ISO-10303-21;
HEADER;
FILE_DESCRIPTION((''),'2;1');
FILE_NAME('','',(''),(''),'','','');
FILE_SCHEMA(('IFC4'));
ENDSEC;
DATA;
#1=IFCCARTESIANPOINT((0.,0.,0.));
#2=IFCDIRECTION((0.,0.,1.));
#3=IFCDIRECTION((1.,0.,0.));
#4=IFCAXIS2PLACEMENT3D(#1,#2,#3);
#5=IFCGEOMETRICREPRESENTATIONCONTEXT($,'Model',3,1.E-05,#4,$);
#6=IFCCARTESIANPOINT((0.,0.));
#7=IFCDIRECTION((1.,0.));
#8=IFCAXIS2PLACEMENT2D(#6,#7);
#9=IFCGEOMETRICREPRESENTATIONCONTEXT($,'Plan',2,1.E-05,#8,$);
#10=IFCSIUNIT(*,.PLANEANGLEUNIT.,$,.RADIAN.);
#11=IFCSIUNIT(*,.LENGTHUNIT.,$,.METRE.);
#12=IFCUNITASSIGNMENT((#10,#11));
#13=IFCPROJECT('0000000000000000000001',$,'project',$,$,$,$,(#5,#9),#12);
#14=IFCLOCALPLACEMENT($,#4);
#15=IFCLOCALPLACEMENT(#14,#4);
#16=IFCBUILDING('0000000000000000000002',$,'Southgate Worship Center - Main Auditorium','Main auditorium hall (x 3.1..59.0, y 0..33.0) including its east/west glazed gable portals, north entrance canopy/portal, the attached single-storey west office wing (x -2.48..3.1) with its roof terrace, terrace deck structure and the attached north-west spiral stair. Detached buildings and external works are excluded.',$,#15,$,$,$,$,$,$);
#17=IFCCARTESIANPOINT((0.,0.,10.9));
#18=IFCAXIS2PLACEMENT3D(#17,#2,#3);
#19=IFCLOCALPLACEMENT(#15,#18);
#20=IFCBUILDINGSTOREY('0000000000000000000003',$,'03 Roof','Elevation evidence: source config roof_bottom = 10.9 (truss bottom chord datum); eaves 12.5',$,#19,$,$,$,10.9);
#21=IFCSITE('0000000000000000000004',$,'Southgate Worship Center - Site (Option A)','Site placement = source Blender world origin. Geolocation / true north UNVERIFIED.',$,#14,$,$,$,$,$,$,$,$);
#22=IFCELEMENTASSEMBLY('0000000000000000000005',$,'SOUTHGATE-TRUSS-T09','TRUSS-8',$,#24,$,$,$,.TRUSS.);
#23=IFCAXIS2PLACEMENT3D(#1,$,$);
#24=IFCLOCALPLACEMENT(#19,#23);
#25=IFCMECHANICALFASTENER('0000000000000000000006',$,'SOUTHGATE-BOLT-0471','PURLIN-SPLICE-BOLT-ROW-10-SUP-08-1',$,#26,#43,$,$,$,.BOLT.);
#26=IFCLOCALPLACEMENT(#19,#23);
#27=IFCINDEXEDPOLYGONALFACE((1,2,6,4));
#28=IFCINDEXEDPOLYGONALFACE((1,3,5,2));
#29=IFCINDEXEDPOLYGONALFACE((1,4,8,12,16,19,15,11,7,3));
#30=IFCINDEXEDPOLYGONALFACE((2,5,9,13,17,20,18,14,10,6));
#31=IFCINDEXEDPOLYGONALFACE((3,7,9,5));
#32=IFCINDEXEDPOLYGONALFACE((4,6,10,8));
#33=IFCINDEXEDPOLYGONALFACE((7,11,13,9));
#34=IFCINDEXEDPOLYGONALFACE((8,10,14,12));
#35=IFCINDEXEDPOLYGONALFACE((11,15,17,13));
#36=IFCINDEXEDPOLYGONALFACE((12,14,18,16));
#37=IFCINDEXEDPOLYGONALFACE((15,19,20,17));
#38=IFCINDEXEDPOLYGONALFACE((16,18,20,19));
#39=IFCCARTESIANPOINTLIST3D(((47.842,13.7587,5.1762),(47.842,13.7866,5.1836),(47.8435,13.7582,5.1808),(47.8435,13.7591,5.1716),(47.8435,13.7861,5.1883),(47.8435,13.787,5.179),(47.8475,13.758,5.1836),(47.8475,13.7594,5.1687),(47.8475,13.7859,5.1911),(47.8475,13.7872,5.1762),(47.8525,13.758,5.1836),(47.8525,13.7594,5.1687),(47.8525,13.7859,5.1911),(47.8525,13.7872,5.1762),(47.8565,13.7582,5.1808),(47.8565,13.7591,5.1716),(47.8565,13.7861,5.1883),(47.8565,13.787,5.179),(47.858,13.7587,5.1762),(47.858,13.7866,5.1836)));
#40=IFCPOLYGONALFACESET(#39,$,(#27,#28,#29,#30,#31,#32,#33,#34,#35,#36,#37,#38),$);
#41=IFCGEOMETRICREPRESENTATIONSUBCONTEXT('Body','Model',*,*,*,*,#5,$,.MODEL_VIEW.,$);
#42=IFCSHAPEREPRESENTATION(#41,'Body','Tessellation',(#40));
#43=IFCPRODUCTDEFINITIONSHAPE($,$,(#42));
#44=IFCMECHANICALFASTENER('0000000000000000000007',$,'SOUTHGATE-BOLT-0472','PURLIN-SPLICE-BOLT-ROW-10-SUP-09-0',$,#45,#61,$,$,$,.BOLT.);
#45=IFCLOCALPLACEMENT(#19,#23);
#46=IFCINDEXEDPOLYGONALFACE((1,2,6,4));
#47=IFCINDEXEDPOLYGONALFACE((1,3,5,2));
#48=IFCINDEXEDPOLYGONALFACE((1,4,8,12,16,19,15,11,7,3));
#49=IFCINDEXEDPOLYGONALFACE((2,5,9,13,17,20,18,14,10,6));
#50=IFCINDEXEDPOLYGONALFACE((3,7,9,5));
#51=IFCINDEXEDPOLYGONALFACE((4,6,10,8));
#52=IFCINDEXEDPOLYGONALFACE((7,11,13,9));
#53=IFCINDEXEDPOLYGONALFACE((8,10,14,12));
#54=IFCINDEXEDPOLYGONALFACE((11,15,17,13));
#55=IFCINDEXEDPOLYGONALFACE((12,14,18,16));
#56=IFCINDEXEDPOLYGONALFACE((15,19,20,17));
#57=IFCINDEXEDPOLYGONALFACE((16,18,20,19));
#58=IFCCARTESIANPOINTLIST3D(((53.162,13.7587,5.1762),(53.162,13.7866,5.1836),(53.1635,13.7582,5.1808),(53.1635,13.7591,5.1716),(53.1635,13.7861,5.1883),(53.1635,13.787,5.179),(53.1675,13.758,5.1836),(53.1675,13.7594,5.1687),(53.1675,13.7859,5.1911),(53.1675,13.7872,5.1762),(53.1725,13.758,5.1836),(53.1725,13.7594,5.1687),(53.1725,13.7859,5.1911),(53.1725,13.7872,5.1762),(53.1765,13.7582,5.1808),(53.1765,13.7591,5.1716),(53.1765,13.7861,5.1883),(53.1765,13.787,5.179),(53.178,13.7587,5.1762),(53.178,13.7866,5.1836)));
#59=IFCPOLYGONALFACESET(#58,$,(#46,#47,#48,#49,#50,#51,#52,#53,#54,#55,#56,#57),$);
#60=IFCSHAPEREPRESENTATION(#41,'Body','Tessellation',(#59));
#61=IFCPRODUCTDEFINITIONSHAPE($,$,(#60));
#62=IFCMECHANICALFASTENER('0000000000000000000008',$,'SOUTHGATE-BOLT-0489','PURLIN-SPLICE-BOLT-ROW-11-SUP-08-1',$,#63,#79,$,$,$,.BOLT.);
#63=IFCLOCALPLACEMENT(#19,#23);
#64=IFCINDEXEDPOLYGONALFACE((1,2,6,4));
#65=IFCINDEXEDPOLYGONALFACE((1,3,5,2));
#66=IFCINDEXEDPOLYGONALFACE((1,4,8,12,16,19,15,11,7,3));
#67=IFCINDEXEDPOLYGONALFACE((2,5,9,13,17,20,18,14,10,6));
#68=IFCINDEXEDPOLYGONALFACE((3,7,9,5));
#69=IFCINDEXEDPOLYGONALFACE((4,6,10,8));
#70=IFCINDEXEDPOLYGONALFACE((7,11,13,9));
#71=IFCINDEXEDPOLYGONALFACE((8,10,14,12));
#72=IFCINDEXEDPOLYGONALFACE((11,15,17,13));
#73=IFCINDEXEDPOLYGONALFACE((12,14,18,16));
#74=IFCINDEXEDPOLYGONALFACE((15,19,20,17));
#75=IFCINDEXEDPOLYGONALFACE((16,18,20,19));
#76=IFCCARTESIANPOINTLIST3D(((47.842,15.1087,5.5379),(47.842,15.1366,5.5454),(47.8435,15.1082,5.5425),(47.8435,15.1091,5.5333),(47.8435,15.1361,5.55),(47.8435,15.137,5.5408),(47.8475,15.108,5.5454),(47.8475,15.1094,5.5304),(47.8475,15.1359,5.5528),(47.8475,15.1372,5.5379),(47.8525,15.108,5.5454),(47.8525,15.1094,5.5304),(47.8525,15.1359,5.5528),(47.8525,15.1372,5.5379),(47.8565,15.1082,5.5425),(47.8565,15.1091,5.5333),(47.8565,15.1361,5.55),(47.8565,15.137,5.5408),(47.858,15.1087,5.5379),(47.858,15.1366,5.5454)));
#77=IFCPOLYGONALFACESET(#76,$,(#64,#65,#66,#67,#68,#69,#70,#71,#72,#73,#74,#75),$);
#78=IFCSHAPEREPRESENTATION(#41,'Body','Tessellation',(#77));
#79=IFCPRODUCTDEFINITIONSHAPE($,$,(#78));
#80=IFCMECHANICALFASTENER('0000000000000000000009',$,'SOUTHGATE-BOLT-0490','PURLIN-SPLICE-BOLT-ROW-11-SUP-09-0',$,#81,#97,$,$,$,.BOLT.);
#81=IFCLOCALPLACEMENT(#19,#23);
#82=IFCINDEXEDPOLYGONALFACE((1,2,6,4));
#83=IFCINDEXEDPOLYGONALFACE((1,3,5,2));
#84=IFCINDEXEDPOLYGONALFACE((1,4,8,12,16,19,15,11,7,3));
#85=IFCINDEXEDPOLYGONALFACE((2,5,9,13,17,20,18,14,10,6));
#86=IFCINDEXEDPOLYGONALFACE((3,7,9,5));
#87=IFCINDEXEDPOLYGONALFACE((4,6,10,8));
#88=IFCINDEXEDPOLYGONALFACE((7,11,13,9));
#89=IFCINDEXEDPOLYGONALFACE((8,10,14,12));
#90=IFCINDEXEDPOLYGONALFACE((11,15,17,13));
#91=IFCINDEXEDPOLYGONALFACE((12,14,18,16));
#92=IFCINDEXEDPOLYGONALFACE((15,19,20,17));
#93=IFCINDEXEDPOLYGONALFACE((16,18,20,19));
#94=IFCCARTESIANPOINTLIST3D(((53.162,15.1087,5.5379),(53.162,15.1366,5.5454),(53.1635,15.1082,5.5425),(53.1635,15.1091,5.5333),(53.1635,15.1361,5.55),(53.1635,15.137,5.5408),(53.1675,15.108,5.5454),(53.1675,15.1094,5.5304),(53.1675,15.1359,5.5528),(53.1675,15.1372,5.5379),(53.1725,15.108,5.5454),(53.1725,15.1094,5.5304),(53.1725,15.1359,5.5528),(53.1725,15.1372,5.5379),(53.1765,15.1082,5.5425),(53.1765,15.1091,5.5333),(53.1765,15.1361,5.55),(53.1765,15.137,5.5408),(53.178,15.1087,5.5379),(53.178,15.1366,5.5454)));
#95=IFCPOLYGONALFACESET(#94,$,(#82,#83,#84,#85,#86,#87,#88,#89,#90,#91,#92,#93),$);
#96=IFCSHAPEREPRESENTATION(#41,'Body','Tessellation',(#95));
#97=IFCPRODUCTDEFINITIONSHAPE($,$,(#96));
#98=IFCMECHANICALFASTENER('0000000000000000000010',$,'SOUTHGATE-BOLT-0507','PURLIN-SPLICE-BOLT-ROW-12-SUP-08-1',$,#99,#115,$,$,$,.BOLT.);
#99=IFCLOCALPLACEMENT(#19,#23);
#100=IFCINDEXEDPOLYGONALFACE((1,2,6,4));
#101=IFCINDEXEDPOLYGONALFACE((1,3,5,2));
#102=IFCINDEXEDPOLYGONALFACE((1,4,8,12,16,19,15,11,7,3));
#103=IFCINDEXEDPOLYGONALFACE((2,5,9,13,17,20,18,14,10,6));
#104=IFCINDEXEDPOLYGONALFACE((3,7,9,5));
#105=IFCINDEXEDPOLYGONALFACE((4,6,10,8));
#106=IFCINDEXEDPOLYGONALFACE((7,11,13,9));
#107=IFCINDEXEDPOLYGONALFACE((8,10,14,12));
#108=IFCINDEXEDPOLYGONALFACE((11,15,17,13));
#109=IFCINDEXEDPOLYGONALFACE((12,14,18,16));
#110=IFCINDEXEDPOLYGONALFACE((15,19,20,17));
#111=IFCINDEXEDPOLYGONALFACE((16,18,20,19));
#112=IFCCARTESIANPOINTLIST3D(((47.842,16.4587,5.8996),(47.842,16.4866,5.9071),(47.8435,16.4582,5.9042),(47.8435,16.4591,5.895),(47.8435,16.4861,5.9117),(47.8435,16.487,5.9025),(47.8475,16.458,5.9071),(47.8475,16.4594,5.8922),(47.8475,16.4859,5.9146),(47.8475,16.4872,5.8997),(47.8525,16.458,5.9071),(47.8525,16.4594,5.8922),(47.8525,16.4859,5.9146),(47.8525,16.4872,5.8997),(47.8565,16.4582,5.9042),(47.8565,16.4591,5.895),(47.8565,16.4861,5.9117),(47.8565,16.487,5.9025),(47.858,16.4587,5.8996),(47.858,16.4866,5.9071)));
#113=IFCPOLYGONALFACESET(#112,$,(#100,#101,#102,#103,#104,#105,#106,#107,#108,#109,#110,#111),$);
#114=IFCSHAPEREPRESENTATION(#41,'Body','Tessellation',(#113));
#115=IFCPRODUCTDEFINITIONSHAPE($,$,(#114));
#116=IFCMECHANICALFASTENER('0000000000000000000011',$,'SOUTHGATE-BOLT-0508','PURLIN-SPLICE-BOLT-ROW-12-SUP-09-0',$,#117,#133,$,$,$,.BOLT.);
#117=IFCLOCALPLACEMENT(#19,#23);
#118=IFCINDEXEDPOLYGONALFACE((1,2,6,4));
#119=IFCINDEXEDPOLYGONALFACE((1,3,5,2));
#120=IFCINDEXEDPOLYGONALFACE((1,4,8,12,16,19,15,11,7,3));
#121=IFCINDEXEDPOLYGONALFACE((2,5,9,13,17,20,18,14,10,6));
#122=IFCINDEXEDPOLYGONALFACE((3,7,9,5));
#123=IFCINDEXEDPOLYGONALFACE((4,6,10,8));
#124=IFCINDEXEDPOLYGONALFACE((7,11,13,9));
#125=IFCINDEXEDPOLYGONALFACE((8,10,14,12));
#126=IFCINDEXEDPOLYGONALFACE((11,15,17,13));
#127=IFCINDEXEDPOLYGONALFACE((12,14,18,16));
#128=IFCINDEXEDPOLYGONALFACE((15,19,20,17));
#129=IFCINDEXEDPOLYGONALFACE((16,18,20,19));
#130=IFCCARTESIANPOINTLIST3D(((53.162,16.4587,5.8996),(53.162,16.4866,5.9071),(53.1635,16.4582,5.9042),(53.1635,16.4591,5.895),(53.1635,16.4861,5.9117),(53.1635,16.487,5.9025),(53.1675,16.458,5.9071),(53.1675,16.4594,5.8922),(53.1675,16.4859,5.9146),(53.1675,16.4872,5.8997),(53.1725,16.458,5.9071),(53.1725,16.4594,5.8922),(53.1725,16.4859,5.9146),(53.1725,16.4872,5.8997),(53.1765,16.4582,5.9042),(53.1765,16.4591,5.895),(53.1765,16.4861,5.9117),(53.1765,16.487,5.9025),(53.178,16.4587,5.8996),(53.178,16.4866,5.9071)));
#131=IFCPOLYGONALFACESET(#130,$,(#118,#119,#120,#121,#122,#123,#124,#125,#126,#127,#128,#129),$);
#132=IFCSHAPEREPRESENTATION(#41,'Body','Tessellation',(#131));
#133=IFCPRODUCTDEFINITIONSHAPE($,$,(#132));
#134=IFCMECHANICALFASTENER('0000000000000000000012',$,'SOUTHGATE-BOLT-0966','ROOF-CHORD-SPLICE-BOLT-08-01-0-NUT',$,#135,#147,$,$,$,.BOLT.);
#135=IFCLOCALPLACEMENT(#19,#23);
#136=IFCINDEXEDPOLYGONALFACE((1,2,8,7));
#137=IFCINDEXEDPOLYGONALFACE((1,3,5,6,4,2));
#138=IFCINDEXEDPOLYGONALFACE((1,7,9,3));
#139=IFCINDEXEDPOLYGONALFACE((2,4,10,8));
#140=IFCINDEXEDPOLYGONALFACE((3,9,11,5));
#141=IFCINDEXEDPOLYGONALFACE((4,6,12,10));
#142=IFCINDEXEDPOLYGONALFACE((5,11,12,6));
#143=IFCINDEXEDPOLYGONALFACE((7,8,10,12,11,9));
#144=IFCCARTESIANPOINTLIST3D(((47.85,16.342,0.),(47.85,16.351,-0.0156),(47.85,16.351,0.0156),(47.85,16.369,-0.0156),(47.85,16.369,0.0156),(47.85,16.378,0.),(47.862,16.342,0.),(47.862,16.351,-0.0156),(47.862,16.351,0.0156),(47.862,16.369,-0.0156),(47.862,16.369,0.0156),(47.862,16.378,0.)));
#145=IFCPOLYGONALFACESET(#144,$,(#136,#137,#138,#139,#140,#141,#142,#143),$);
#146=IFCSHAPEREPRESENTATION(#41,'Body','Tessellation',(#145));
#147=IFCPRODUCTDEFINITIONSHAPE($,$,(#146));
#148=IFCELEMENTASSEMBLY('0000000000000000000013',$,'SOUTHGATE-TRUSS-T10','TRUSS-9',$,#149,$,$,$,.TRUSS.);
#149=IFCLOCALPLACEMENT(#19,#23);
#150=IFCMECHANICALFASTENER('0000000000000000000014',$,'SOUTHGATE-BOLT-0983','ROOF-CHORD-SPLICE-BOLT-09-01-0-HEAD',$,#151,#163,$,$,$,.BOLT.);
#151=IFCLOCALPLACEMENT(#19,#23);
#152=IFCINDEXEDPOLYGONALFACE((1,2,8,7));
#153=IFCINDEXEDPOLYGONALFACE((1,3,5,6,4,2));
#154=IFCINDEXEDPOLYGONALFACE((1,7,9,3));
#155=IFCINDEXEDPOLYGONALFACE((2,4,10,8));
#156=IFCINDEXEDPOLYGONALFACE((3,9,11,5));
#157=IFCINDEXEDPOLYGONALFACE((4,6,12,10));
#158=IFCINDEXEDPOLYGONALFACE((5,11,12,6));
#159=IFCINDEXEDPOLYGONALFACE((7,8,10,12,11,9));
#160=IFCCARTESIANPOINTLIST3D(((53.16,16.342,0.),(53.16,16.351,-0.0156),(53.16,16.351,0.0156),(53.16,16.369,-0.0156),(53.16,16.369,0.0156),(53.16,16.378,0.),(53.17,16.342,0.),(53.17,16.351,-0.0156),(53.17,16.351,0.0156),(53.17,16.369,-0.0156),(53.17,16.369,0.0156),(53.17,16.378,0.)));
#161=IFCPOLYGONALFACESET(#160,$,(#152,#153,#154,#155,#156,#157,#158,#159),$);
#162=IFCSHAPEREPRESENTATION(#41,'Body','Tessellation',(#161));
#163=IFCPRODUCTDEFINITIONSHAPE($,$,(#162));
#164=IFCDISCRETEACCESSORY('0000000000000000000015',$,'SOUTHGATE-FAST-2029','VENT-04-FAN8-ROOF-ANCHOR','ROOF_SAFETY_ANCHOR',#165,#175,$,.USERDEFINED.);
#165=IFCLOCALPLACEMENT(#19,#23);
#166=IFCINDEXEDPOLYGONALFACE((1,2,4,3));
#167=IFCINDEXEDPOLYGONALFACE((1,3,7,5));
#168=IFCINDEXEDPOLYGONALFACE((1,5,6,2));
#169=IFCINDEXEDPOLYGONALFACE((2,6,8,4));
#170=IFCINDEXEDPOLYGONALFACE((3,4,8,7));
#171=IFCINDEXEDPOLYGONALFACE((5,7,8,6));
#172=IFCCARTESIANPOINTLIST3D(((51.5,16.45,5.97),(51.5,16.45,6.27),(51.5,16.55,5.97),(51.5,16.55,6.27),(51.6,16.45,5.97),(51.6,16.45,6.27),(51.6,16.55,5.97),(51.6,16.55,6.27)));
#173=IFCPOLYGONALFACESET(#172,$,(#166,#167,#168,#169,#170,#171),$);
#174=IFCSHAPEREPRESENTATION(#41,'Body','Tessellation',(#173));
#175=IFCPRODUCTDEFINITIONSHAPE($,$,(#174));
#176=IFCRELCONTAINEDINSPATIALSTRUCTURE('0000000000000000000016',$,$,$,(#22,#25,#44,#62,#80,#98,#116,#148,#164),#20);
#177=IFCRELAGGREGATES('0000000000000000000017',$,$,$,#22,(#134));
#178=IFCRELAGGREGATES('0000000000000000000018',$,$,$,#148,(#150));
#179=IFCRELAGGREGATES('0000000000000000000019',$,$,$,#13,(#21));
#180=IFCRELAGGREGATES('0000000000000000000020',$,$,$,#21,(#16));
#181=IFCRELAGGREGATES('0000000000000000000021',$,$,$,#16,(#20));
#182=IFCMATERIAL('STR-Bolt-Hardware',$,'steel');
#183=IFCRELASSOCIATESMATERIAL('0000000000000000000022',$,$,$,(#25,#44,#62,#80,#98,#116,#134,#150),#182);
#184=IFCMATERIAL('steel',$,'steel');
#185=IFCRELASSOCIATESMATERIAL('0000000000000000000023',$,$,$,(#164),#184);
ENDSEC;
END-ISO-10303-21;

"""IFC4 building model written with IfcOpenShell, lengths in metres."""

from ifc_helpers import new_model, si_unit, frame, origin_with_axes, origin_2d, origin_2d_with_axis, place, context, subcontext, project, spatial, indexed_curve, rectangle, outline, extrude, clip, halfspace, material, element, aggregate, save


model = new_model("IFC4")

# Units and contexts
model_context = context("Model", 3, precision=1e-05, world=origin_with_axes())
plan_context = context("Plan", 2, precision=1e-05, world=origin_2d_with_axis())
body_context = subcontext(model_context, "Body", "Model", "MODEL_VIEW")
ifc_project = project(units=[si_unit("PLANEANGLEUNIT", "RADIAN"), si_unit("LENGTHUNIT", "METRE")], contexts=[model_context, plan_context])

# Site, building, storey
site_placement = place(None, origin_with_axes())
site = spatial("IfcSite", under=ifc_project, at=site_placement, Name="Southgate Worship Center - Site (Option A)", Description="Site placement = source Blender world origin. Geolocation / true north UNVERIFIED.")
building_placement = place(site_placement, origin_with_axes())
building = spatial("IfcBuilding", under=site, at=building_placement, Name="Southgate Worship Center - Main Auditorium", Description="Main auditorium hall (x 3.1..59.0, y 0..33.0) including its east/west glazed gable portals, north entrance canopy/portal, the attached single-storey west office wing (x -2.48..3.1) with its roof terrace, terrace deck structure and the attached north-west spiral stair. Detached buildings and external works are excluded.")
storey_placement = place(building_placement, frame((0.0, 0.0, 10.9), z_axis=(0.0, 0.0, 1.0), x_axis=(1.0, 0.0, 0.0)))
storey = spatial("IfcBuildingStorey", under=building, at=storey_placement, Name="03 Roof", Description="Elevation evidence: source config roof_bottom = 10.9 (truss bottom chord datum); eaves 12.5", Elevation=10.9)

# Element assembly
assembly_1_placement = place(storey_placement, origin_with_axes())
assembly_1 = element("IfcElementAssembly", 1, at=assembly_1_placement, inside=storey, Name="SOUTHGATE-TRUSS-T09", Description="TRUSS-8", PredefinedType="TRUSS")

# Shared definitions
ifc_material_1 = material(Name="steel", Category="steel")

# Mechanical fasteners
ifc_material_2 = material(Name="STR-Bolt-Hardware", Category="steel")
mechanical_fastener_1_placement = place(storey_placement, frame((47.842, 13.758, 5.1687), z_axis=(0.0, 0.0, 1.0), x_axis=(1.0, 0.0, 0.0)))
element("IfcMechanicalFastener", 2, at=mechanical_fastener_1_placement, inside=storey, material=ifc_material_2, Name="SOUTHGATE-BOLT-0471", Description="PURLIN-SPLICE-BOLT-ROW-10-SUP-08-1", PredefinedType="BOLT", context=body_context, shape_type="Clipping", body=[
    clip(clip(extrude(outline(indexed_curve([(0.0, 0.0), (-0.004, -0.0028), (-0.0055, -0.0074), (-0.004, -0.0119), (0.0, -0.0148), (0.0049, -0.0148), (0.0089, -0.0119), (0.0105, -0.0074), (0.0089, -0.0028), (0.0049, 0.0), (0.0, 0.0)], self_intersect=False)), frame((0.0105, -0.0025, 0.0143), z_axis=(0.0, 0.965916, 0.258855), x_axis=(-1.0, 0.0, 0.0)), (0.0, 0.0, 1.0), 0.0314), halfspace(frame((0.008, 0.0007, 0.0075), z_axis=(0.0, -0.995763, -0.09196), x_axis=(1.0, 0.0, 0.0)), False)), halfspace(frame((0.008, 0.0286, 0.0149), z_axis=(0.0, 0.995763, 0.09196), x_axis=(-1.0, 0.0, 0.0)), False)),
])
mechanical_fastener_2_placement = place(storey_placement, frame((53.162, 13.758, 5.1687), z_axis=(0.0, 0.0, 1.0), x_axis=(1.0, 0.0, 0.0)))
element("IfcMechanicalFastener", 3, at=mechanical_fastener_2_placement, inside=storey, material=ifc_material_2, Name="SOUTHGATE-BOLT-0472", Description="PURLIN-SPLICE-BOLT-ROW-10-SUP-09-0", PredefinedType="BOLT", context=body_context, shape_type="Clipping", body=[
    clip(clip(extrude(outline(indexed_curve([(0.0, 0.0), (-0.004, -0.0028), (-0.0055, -0.0074), (-0.004, -0.0119), (0.0, -0.0148), (0.0049, -0.0148), (0.0089, -0.0119), (0.0105, -0.0074), (0.0089, -0.0028), (0.0049, 0.0), (0.0, 0.0)], self_intersect=False)), frame((0.0105, -0.0025, 0.0143), z_axis=(0.0, 0.965916, 0.258855), x_axis=(-1.0, 0.0, 0.0)), (0.0, 0.0, 1.0), 0.0314), halfspace(frame((0.008, 0.0007, 0.0075), z_axis=(0.0, -0.995763, -0.09196), x_axis=(1.0, 0.0, 0.0)), False)), halfspace(frame((0.008, 0.0286, 0.0149), z_axis=(0.0, 0.995763, 0.09196), x_axis=(-1.0, 0.0, 0.0)), False)),
])
mechanical_fastener_3_placement = place(storey_placement, frame((47.842, 15.108, 5.5304), z_axis=(0.0, 0.0, 1.0), x_axis=(1.0, 0.0, 0.0)))
element("IfcMechanicalFastener", 4, at=mechanical_fastener_3_placement, inside=storey, material=ifc_material_2, Name="SOUTHGATE-BOLT-0489", Description="PURLIN-SPLICE-BOLT-ROW-11-SUP-08-1", PredefinedType="BOLT", context=body_context, shape_type="Clipping", body=[
    clip(clip(extrude(outline(indexed_curve([(0.0, 0.0), (-0.004, -0.0028), (-0.0055, -0.0074), (-0.004, -0.0119), (0.0, -0.0148), (0.0049, -0.0148), (0.0089, -0.0119), (0.0105, -0.0074), (0.0089, -0.0028), (0.0049, 0.0), (0.0, 0.0)], self_intersect=False)), frame((0.0105, -0.0025, 0.0143), z_axis=(0.0, 0.965916, 0.258855), x_axis=(-1.0, 0.0, 0.0)), (0.0, 0.0, 1.0), 0.0314), halfspace(frame((0.008, 0.0007, 0.0075), z_axis=(0.0, -0.995763, -0.09196), x_axis=(1.0, 0.0, 0.0)), False)), halfspace(frame((0.008, 0.0286, 0.015), z_axis=(0.0, 0.995763, 0.09196), x_axis=(-1.0, 0.0, 0.0)), False)),
])
mechanical_fastener_4_placement = place(storey_placement, frame((53.162, 15.108, 5.5304), z_axis=(0.0, 0.0, 1.0), x_axis=(1.0, 0.0, 0.0)))
element("IfcMechanicalFastener", 5, at=mechanical_fastener_4_placement, inside=storey, material=ifc_material_2, Name="SOUTHGATE-BOLT-0490", Description="PURLIN-SPLICE-BOLT-ROW-11-SUP-09-0", PredefinedType="BOLT", context=body_context, shape_type="Clipping", body=[
    clip(clip(extrude(outline(indexed_curve([(0.0, 0.0), (-0.004, -0.0028), (-0.0055, -0.0074), (-0.004, -0.0119), (0.0, -0.0148), (0.0049, -0.0148), (0.0089, -0.0119), (0.0105, -0.0074), (0.0089, -0.0028), (0.0049, 0.0), (0.0, 0.0)], self_intersect=False)), frame((0.0105, -0.0025, 0.0143), z_axis=(0.0, 0.965916, 0.258855), x_axis=(-1.0, 0.0, 0.0)), (0.0, 0.0, 1.0), 0.0314), halfspace(frame((0.008, 0.0007, 0.0075), z_axis=(0.0, -0.995763, -0.09196), x_axis=(1.0, 0.0, 0.0)), False)), halfspace(frame((0.008, 0.0286, 0.015), z_axis=(0.0, 0.995763, 0.09196), x_axis=(-1.0, 0.0, 0.0)), False)),
])
mechanical_fastener_5_placement = place(storey_placement, frame((47.842, 16.458, 5.8922), z_axis=(0.0, 0.0, 1.0), x_axis=(1.0, 0.0, 0.0)))
element("IfcMechanicalFastener", 6, at=mechanical_fastener_5_placement, inside=storey, material=ifc_material_2, Name="SOUTHGATE-BOLT-0507", Description="PURLIN-SPLICE-BOLT-ROW-12-SUP-08-1", PredefinedType="BOLT", context=body_context, shape_type="Clipping", body=[
    clip(clip(extrude(outline(indexed_curve([(0.0, 0.0), (-0.004, -0.0028), (-0.0055, -0.0074), (-0.004, -0.0119), (0.0, -0.0148), (0.0049, -0.0148), (0.0089, -0.0119), (0.0105, -0.0074), (0.0089, -0.0028), (0.0049, 0.0), (0.0, 0.0)], self_intersect=False)), frame((0.0105, -0.0025, 0.0142), z_axis=(0.0, 0.965916, 0.258855), x_axis=(-1.0, 0.0, 0.0)), (0.0, 0.0, 1.0), 0.0314), halfspace(frame((0.008, 0.0007, 0.0074), z_axis=(0.0, -0.995763, -0.09196), x_axis=(1.0, 0.0, 0.0)), False)), halfspace(frame((0.008, 0.0286, 0.0149), z_axis=(0.0, 0.995763, 0.09196), x_axis=(-1.0, 0.0, 0.0)), False)),
])
mechanical_fastener_6_placement = place(storey_placement, frame((53.162, 16.458, 5.8922), z_axis=(0.0, 0.0, 1.0), x_axis=(1.0, 0.0, 0.0)))
element("IfcMechanicalFastener", 7, at=mechanical_fastener_6_placement, inside=storey, material=ifc_material_2, Name="SOUTHGATE-BOLT-0508", Description="PURLIN-SPLICE-BOLT-ROW-12-SUP-09-0", PredefinedType="BOLT", context=body_context, shape_type="Clipping", body=[
    clip(clip(extrude(outline(indexed_curve([(0.0, 0.0), (-0.004, -0.0028), (-0.0055, -0.0074), (-0.004, -0.0119), (0.0, -0.0148), (0.0049, -0.0148), (0.0089, -0.0119), (0.0105, -0.0074), (0.0089, -0.0028), (0.0049, 0.0), (0.0, 0.0)], self_intersect=False)), frame((0.0105, -0.0025, 0.0142), z_axis=(0.0, 0.965916, 0.258855), x_axis=(-1.0, 0.0, 0.0)), (0.0, 0.0, 1.0), 0.0314), halfspace(frame((0.008, 0.0007, 0.0074), z_axis=(0.0, -0.995763, -0.09196), x_axis=(1.0, 0.0, 0.0)), False)), halfspace(frame((0.008, 0.0286, 0.0149), z_axis=(0.0, 0.995763, 0.09196), x_axis=(-1.0, 0.0, 0.0)), False)),
])

# Mechanical fastener
mechanical_fastener_7_placement = place(assembly_1_placement, frame((47.85, 16.342, -0.0156), z_axis=(0.0, 0.0, 1.0), x_axis=(1.0, 0.0, 0.0)))
mechanical_fastener_7 = element("IfcMechanicalFastener", 8, at=mechanical_fastener_7_placement, material=ifc_material_2, Name="SOUTHGATE-BOLT-0966", Description="ROOF-CHORD-SPLICE-BOLT-08-01-0-NUT", PredefinedType="BOLT", context=body_context, shape_type="SweptSolid", body=[
    extrude(outline(indexed_curve([(0.0, 0.0), (0.009, -0.0156), (0.027, -0.0156), (0.036, 0.0), (0.027, 0.0156), (0.009, 0.0156), (0.0, 0.0)], self_intersect=False)), frame((0.0, 0.0, 0.0156), z_axis=(1.0, 0.0, 0.0), x_axis=(0.0, 1.0, 0.0)), (0.0, 0.0, 1.0), 0.012),
])
aggregate(assembly_1, [mechanical_fastener_7])

# Element assembly, mechanical fastener
assembly_2_placement = place(storey_placement, origin_with_axes())
assembly_2 = element("IfcElementAssembly", 9, at=assembly_2_placement, inside=storey, Name="SOUTHGATE-TRUSS-T10", Description="TRUSS-9", PredefinedType="TRUSS")
mechanical_fastener_8_placement = place(assembly_2_placement, frame((53.16, 16.342, -0.0156), z_axis=(0.0, 0.0, 1.0), x_axis=(1.0, 0.0, 0.0)))
mechanical_fastener_8 = element("IfcMechanicalFastener", 10, at=mechanical_fastener_8_placement, material=ifc_material_2, Name="SOUTHGATE-BOLT-0983", Description="ROOF-CHORD-SPLICE-BOLT-09-01-0-HEAD", PredefinedType="BOLT", context=body_context, shape_type="SweptSolid", body=[
    extrude(outline(indexed_curve([(0.0, 0.0), (0.009, -0.0156), (0.027, -0.0156), (0.036, 0.0), (0.027, 0.0156), (0.009, 0.0156), (0.0, 0.0)], self_intersect=False)), frame((0.0, 0.0, 0.0156), z_axis=(1.0, 0.0, 0.0), x_axis=(0.0, 1.0, 0.0)), (0.0, 0.0, 1.0), 0.01),
])
aggregate(assembly_2, [mechanical_fastener_8])

# Discrete accessory
discrete_accessory_1_placement = place(storey_placement, frame((51.5, 16.45, 5.97), z_axis=(0.0, 0.0, 1.0), x_axis=(1.0, 0.0, 0.0)))
element("IfcDiscreteAccessory", 11, at=discrete_accessory_1_placement, inside=storey, material=ifc_material_1, Name="SOUTHGATE-FAST-2029", Description="VENT-04-FAN8-ROOF-ANCHOR", ObjectType="ROOF_SAFETY_ANCHOR", PredefinedType="USERDEFINED", context=body_context, shape_type="SweptSolid", body=[
    extrude(rectangle(XDim=0.1, YDim=0.1, at=origin_2d()), frame((0.05, 0.05, 0.0), z_axis=(0.0, 0.0, 1.0), x_axis=(0.0, 1.0, 0.0)), (0.0, 0.0, 1.0), 0.3),
])

save(model, "model.ifc")
